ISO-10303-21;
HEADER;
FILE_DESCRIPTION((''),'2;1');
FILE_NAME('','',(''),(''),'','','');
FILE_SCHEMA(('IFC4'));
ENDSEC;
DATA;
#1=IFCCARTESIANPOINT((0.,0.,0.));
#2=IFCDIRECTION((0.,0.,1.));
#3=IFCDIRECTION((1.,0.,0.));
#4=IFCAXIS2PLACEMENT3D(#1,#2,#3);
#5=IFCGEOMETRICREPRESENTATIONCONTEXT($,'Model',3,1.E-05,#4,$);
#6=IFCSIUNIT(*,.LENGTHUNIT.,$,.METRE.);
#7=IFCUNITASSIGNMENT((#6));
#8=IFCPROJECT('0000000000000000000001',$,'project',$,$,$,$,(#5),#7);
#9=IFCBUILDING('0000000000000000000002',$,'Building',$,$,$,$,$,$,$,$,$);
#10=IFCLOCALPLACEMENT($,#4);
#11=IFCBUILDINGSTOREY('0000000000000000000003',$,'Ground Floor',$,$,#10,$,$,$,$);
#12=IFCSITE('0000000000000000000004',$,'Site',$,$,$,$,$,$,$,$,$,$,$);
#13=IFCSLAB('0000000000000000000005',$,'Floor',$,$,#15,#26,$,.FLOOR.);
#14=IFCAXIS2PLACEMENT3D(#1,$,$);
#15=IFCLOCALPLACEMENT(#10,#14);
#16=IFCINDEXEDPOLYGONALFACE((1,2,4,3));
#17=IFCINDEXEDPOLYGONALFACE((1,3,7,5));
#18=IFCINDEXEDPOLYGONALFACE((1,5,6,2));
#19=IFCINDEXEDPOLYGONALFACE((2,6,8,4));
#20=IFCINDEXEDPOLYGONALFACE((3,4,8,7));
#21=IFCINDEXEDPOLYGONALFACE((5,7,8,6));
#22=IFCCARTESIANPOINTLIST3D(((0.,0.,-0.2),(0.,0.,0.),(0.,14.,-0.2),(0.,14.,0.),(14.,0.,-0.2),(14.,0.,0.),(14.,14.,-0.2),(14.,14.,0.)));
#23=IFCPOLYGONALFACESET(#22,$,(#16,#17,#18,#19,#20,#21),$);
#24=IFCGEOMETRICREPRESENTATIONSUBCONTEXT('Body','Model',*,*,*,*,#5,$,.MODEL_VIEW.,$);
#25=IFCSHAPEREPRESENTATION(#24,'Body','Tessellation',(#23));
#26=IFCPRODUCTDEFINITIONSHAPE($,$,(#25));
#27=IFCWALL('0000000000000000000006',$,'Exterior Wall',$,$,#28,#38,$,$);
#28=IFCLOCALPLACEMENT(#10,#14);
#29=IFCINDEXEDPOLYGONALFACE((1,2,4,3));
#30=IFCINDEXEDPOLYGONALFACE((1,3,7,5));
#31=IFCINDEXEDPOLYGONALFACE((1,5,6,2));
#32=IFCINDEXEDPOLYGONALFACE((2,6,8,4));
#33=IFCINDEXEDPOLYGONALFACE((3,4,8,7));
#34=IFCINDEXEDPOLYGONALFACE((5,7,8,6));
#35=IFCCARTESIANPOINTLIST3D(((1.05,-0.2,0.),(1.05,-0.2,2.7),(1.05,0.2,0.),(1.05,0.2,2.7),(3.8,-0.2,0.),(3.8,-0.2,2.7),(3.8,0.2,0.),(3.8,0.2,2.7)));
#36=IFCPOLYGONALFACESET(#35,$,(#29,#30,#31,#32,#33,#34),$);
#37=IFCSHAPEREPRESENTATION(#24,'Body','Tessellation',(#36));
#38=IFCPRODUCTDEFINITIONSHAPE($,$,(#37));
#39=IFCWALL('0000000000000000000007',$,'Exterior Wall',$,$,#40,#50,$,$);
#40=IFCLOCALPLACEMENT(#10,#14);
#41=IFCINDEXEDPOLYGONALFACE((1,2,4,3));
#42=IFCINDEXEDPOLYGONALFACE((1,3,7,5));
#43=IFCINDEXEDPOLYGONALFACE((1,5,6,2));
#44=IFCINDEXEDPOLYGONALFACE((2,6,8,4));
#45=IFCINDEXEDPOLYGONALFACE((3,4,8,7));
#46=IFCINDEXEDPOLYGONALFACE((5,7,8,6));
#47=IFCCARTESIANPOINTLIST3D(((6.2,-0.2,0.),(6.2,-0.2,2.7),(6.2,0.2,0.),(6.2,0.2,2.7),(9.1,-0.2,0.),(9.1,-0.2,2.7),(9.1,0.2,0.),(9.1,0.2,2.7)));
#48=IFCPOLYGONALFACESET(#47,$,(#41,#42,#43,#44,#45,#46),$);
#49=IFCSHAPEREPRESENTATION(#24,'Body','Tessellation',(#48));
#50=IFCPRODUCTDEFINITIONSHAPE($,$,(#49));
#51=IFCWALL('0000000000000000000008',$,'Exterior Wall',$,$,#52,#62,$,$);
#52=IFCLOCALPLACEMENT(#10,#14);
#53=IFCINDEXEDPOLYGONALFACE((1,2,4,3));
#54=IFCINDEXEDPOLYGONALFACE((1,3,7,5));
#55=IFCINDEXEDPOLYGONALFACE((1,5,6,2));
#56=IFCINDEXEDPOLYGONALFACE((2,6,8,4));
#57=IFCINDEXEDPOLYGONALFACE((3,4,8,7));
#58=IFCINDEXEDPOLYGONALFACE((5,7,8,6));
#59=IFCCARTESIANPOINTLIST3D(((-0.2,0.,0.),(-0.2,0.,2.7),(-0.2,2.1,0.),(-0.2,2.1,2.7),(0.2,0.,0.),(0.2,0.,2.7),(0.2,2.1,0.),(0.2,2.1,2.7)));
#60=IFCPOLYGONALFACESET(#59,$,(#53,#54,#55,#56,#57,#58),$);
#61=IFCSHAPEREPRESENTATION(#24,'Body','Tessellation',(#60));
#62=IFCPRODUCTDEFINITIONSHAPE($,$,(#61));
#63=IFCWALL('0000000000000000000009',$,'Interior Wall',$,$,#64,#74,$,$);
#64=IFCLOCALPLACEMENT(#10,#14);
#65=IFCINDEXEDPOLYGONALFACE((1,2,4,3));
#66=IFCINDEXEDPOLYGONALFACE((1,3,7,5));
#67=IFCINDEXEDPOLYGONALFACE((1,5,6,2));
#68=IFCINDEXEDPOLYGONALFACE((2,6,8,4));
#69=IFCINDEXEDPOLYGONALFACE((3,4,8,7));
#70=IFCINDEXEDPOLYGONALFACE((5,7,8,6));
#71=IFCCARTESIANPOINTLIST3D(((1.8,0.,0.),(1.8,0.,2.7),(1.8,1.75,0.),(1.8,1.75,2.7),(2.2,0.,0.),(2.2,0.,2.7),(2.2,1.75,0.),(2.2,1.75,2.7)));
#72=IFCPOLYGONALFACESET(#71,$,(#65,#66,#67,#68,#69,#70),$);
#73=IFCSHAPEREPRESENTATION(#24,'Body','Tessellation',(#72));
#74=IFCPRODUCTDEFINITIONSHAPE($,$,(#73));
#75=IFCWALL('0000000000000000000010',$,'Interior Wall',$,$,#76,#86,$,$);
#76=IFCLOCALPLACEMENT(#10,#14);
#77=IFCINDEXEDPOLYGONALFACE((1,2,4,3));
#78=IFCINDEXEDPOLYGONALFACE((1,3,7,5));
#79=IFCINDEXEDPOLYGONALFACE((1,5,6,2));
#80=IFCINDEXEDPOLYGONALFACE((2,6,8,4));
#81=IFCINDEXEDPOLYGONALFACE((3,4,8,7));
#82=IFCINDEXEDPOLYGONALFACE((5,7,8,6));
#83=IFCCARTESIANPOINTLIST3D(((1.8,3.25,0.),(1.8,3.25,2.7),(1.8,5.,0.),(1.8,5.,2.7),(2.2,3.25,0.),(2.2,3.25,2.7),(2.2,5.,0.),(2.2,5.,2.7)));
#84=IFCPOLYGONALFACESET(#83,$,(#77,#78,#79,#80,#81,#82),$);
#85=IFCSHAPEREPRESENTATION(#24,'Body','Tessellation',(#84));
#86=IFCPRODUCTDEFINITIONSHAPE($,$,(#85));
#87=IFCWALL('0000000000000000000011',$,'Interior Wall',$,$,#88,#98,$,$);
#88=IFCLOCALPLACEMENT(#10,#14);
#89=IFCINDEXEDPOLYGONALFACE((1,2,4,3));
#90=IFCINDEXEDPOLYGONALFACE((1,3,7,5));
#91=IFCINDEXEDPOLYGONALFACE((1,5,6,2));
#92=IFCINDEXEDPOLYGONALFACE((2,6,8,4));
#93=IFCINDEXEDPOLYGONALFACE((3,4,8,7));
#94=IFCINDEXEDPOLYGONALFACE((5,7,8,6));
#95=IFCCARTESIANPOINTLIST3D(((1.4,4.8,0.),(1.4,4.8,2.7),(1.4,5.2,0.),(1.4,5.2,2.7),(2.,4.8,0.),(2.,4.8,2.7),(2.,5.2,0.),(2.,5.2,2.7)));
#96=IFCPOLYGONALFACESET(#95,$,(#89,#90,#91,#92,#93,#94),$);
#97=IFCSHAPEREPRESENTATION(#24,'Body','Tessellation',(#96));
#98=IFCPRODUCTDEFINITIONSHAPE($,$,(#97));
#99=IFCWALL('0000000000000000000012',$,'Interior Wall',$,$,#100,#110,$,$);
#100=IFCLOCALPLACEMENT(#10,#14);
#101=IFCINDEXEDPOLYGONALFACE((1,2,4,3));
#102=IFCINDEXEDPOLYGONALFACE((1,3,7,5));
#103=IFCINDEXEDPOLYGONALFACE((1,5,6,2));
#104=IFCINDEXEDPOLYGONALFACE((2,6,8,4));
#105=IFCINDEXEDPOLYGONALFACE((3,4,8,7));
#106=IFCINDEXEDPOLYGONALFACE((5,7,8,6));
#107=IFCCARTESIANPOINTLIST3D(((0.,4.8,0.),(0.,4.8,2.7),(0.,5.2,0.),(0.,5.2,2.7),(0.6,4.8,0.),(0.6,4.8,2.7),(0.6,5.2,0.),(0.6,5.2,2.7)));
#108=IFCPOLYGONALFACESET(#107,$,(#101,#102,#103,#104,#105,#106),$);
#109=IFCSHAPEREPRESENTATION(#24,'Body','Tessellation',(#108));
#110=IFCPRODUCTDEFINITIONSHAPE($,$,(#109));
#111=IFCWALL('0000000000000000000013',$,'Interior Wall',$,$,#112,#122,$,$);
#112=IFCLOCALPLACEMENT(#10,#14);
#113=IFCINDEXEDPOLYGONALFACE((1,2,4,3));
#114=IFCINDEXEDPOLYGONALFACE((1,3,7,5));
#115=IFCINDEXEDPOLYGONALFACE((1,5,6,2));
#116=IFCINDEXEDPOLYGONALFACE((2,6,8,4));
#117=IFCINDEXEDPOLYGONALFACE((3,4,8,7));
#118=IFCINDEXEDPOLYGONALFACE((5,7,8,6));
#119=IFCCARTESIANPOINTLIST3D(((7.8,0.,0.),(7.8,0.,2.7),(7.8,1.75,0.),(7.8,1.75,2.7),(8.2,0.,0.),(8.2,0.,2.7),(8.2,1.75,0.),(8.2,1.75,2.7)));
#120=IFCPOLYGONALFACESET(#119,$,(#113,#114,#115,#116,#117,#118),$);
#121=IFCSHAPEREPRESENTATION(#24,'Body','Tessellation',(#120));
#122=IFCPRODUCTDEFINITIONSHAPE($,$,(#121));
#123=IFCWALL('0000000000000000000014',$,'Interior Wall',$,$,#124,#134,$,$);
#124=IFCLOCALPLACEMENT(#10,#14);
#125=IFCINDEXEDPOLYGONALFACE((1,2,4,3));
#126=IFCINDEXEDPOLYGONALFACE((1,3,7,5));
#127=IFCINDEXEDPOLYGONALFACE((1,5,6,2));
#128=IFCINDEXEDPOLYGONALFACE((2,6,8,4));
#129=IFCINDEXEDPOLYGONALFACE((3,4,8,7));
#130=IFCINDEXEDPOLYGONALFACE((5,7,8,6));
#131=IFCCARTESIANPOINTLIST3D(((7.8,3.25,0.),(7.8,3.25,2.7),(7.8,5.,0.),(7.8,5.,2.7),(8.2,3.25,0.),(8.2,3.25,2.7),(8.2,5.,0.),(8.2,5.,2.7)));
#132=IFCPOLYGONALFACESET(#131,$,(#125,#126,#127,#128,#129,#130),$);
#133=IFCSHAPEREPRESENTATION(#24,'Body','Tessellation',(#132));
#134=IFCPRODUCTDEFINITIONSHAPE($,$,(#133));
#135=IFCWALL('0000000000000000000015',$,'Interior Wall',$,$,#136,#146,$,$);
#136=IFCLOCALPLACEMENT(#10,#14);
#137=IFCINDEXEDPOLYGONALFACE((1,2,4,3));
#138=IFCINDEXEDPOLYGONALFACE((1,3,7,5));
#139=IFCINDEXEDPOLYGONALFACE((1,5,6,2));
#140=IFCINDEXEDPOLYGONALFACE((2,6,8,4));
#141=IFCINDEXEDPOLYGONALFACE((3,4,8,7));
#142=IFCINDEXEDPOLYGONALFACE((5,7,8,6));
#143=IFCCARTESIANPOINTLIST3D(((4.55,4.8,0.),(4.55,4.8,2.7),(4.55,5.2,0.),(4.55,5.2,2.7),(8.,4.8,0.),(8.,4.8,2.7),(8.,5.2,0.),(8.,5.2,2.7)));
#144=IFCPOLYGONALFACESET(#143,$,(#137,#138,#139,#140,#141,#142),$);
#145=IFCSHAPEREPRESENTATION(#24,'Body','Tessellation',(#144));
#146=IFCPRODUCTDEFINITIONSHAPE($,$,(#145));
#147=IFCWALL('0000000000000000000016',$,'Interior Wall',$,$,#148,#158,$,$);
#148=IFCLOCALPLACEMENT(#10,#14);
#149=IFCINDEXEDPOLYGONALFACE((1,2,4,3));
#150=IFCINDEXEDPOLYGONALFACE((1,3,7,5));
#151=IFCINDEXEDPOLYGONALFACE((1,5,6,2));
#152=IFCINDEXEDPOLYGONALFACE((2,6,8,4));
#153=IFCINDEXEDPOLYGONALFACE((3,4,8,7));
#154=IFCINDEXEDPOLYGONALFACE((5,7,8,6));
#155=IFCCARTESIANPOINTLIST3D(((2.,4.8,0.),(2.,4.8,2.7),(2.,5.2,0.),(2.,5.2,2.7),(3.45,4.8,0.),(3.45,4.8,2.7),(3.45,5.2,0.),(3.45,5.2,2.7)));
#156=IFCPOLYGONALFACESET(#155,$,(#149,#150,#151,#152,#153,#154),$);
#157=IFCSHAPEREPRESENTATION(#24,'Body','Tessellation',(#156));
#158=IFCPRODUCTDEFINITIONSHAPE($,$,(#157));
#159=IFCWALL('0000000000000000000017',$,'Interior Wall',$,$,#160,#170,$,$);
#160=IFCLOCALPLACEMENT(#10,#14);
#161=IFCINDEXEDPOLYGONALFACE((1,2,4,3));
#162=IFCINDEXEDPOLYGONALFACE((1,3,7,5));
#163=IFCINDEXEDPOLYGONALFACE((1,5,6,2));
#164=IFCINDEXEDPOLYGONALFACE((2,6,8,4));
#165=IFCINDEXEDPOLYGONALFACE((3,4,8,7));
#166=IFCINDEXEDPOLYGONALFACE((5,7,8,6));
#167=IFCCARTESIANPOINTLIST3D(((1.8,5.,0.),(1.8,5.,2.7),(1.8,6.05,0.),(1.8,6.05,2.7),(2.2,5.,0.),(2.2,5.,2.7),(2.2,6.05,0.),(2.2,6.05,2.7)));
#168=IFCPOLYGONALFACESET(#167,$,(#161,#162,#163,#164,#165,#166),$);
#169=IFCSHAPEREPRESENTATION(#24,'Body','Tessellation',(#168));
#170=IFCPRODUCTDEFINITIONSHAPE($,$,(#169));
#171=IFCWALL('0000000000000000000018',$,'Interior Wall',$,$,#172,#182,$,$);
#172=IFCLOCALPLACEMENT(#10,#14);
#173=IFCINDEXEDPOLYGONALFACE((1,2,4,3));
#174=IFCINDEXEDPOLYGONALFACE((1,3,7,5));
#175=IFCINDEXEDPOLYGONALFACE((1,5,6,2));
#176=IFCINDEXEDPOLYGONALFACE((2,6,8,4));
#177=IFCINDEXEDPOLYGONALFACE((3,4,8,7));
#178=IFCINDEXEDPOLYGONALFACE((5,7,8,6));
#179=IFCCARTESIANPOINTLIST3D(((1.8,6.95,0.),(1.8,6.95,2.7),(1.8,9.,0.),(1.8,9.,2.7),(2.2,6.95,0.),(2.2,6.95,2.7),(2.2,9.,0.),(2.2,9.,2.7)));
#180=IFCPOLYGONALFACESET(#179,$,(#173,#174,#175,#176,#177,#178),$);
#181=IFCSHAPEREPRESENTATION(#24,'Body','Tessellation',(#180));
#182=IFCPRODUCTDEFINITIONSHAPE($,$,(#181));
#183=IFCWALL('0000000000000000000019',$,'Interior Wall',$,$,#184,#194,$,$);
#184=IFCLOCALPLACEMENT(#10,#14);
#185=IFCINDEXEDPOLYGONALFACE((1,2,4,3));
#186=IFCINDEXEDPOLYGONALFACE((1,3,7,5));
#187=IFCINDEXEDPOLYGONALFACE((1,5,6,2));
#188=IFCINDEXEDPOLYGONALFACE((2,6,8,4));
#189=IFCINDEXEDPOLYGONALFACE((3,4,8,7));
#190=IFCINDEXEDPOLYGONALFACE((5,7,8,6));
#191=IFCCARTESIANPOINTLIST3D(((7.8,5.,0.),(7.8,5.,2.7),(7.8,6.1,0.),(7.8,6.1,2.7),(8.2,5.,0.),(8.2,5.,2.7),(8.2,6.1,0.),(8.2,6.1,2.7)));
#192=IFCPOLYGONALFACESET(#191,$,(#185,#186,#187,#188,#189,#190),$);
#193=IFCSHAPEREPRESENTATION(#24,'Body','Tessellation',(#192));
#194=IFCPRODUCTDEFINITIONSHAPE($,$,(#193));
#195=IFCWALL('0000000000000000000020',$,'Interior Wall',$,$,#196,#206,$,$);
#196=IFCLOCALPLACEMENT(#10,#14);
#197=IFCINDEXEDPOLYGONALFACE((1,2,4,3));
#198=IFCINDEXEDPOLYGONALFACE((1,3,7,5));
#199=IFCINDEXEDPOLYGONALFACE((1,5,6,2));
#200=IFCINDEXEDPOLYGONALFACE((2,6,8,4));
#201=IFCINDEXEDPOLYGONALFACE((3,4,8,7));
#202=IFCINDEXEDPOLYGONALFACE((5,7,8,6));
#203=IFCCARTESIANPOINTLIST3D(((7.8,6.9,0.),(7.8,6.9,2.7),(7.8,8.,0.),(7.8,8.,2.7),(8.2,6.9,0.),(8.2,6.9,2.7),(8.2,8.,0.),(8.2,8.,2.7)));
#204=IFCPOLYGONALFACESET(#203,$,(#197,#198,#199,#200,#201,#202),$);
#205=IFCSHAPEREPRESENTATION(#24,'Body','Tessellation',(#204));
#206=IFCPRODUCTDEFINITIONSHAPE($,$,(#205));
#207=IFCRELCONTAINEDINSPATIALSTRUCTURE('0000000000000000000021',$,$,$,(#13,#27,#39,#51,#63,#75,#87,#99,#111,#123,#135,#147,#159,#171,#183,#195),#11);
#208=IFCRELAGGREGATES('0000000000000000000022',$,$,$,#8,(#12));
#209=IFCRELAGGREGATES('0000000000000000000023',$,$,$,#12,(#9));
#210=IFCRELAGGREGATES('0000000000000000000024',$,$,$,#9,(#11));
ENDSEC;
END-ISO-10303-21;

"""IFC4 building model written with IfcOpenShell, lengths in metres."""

from ifc_helpers import new_model, si_unit, frame, origin_with_axes, place, context, subcontext, project, spatial, indexed_curve, outline, extrude, element, save


model = new_model("IFC4")

# Units and contexts
model_context = context("Model", 3, precision=1e-05, world=origin_with_axes())
body_context = subcontext(model_context, "Body", "Model", "MODEL_VIEW")
ifc_project = project(units=[si_unit("LENGTHUNIT", "METRE")], contexts=[model_context])

# Site, building, storey
site = spatial("IfcSite", under=ifc_project, Name="Site")
building = spatial("IfcBuilding", under=site, Name="Building")
storey_placement = place(None, origin_with_axes())
storey = spatial("IfcBuildingStorey", under=building, at=storey_placement, Name="Ground Floor")

# Slab
slab_placement = place(storey_placement, frame((0.0, 0.0, -0.2), z_axis=(0.0, 0.0, 1.0), x_axis=(1.0, 0.0, 0.0)))
element("IfcSlab", 1, at=slab_placement, inside=storey, Name="Floor", PredefinedType="FLOOR", context=body_context, shape_type="SweptSolid", body=[
    extrude(outline(indexed_curve([(0.0, 0.0), (14.0, 0.0), (14.0, 14.0), (0.0, 14.0)])), None, (0.0, 0.0, 1.0), 0.2),
])

# Walls
wall_1_placement = place(storey_placement, frame((1.05, 0.0, 0.0), z_axis=(0.0, 0.0, 1.0), x_axis=(1.0, 0.0, 0.0)))
element("IfcWall", 2, at=wall_1_placement, inside=storey, Name="Exterior Wall", context=body_context, shape_type="SweptSolid", body=[
    extrude(outline(indexed_curve([(0.0, 0.0), (0.0, 0.4), (2.75, 0.4), (2.75, 0.0), (0.0, 0.0)], self_intersect=False)), frame((0.0, -0.2, 0.0), z_axis=(0.0, 0.0, 1.0), x_axis=(1.0, 0.0, 0.0)), (0.0, 0.0, 1.0), 2.7),
])
wall_2_placement = place(storey_placement, frame((6.2, 0.0, 0.0), z_axis=(0.0, 0.0, 1.0), x_axis=(1.0, 0.0, 0.0)))
element("IfcWall", 3, at=wall_2_placement, inside=storey, Name="Exterior Wall", context=body_context, shape_type="SweptSolid", body=[
    extrude(outline(indexed_curve([(0.0, 0.0), (0.0, 0.4), (2.9, 0.4), (2.9, 0.0), (0.0, 0.0)], self_intersect=False)), frame((0.0, -0.2, 0.0), z_axis=(0.0, 0.0, 1.0), x_axis=(1.0, 0.0, 0.0)), (0.0, 0.0, 1.0), 2.7),
])
wall_3_placement = place(storey_placement, frame((0.0, 2.1, 0.0), z_axis=(0.0, 0.0, 1.0), x_axis=(0.0, -1.0, 0.0)))
element("IfcWall", 4, at=wall_3_placement, inside=storey, Name="Exterior Wall", context=body_context, shape_type="SweptSolid", body=[
    extrude(outline(indexed_curve([(0.0, 0.0), (0.0, 0.4), (2.1, 0.4), (2.1, 0.0), (0.0, 0.0)], self_intersect=False)), frame((0.0, -0.2, 0.0), z_axis=(0.0, 0.0, 1.0), x_axis=(1.0, 0.0, 0.0)), (0.0, 0.0, 1.0), 2.7),
])
for number, where, z_axis, x_axis, name in (
    (5, (2.0, 0.0, 0.0), (0.0, 0.0, 1.0), (0.0, 1.0, 0.0), "Interior Wall"),
    (6, (2.0, 3.25, 0.0), (0.0, 0.0, 1.0), (0.0, 1.0, 0.0), "Interior Wall"),
):
    element("IfcWall", number, at=place(storey_placement, frame(where, z_axis=z_axis, x_axis=x_axis)), inside=storey, Name=name, context=body_context, shape_type="SweptSolid", body=[
        extrude(outline(indexed_curve([(0.0, 0.0), (0.0, 0.4), (1.75, 0.4), (1.75, 0.0), (0.0, 0.0)], self_intersect=False)), frame((0.0, -0.2, 0.0), z_axis=(0.0, 0.0, 1.0), x_axis=(1.0, 0.0, 0.0)), (0.0, 0.0, 1.0), 2.7),
    ])
for number, where, z_axis, x_axis, name in (
    (7, (2.0, 5.0, 0.0), (0.0, 0.0, 1.0), (-1.0, 0.0, 0.0), "Interior Wall"),
    (8, (0.6, 5.0, 0.0), (0.0, 0.0, 1.0), (-1.0, 0.0, 0.0), "Interior Wall"),
):
    element("IfcWall", number, at=place(storey_placement, frame(where, z_axis=z_axis, x_axis=x_axis)), inside=storey, Name=name, context=body_context, shape_type="SweptSolid", body=[
        extrude(outline(indexed_curve([(0.0, 0.0), (0.0, 0.4), (0.6, 0.4), (0.6, 0.0), (0.0, 0.0)], self_intersect=False)), frame((0.0, -0.2, 0.0), z_axis=(0.0, 0.0, 1.0), x_axis=(1.0, 0.0, 0.0)), (0.0, 0.0, 1.0), 2.7),
    ])
for number, where, z_axis, x_axis, name in (
    (9, (8.0, 0.0, 0.0), (0.0, 0.0, 1.0), (0.0, 1.0, 0.0), "Interior Wall"),
    (10, (8.0, 3.25, 0.0), (0.0, 0.0, 1.0), (0.0, 1.0, 0.0), "Interior Wall"),
):
    element("IfcWall", number, at=place(storey_placement, frame(where, z_axis=z_axis, x_axis=x_axis)), inside=storey, Name=name, context=body_context, shape_type="SweptSolid", body=[
        extrude(outline(indexed_curve([(0.0, 0.0), (0.0, 0.4), (1.75, 0.4), (1.75, 0.0), (0.0, 0.0)], self_intersect=False)), frame((0.0, -0.2, 0.0), z_axis=(0.0, 0.0, 1.0), x_axis=(1.0, 0.0, 0.0)), (0.0, 0.0, 1.0), 2.7),
    ])
wall_4_placement = place(storey_placement, frame((8.0, 5.0, 0.0), z_axis=(0.0, 0.0, 1.0), x_axis=(-1.0, 0.0, 0.0)))
element("IfcWall", 11, at=wall_4_placement, inside=storey, Name="Interior Wall", context=body_context, shape_type="SweptSolid", body=[
    extrude(outline(indexed_curve([(0.0, 0.0), (0.0, 0.4), (3.45, 0.4), (3.45, 0.0), (0.0, 0.0)], self_intersect=False)), frame((0.0, -0.2, 0.0), z_axis=(0.0, 0.0, 1.0), x_axis=(1.0, 0.0, 0.0)), (0.0, 0.0, 1.0), 2.7),
])
wall_5_placement = place(storey_placement, frame((3.45, 5.0, 0.0), z_axis=(0.0, 0.0, 1.0), x_axis=(-1.0, 0.0, 0.0)))
element("IfcWall", 12, at=wall_5_placement, inside=storey, Name="Interior Wall", context=body_context, shape_type="SweptSolid", body=[
    extrude(outline(indexed_curve([(0.0, 0.0), (0.0, 0.4), (1.45, 0.4), (1.45, 0.0), (0.0, 0.0)], self_intersect=False)), frame((0.0, -0.2, 0.0), z_axis=(0.0, 0.0, 1.0), x_axis=(1.0, 0.0, 0.0)), (0.0, 0.0, 1.0), 2.7),
])
wall_6_placement = place(storey_placement, frame((2.0, 5.0, 0.0), z_axis=(0.0, 0.0, 1.0), x_axis=(0.0, 1.0, 0.0)))
element("IfcWall", 13, at=wall_6_placement, inside=storey, Name="Interior Wall", context=body_context, shape_type="SweptSolid", body=[
    extrude(outline(indexed_curve([(0.0, 0.0), (0.0, 0.4), (1.05, 0.4), (1.05, 0.0), (0.0, 0.0)], self_intersect=False)), frame((0.0, -0.2, 0.0), z_axis=(0.0, 0.0, 1.0), x_axis=(1.0, 0.0, 0.0)), (0.0, 0.0, 1.0), 2.7),
])
wall_7_placement = place(storey_placement, frame((2.0, 6.95, 0.0), z_axis=(0.0, 0.0, 1.0), x_axis=(0.0, 1.0, 0.0)))
element("IfcWall", 14, at=wall_7_placement, inside=storey, Name="Interior Wall", context=body_context, shape_type="SweptSolid", body=[
    extrude(outline(indexed_curve([(0.0, 0.0), (0.0, 0.4), (2.05, 0.4), (2.05, 0.0), (0.0, 0.0)], self_intersect=False)), frame((0.0, -0.2, 0.0), z_axis=(0.0, 0.0, 1.0), x_axis=(1.0, 0.0, 0.0)), (0.0, 0.0, 1.0), 2.7),
])
for number, where, z_axis, x_axis, name in (
    (15, (8.0, 5.0, 0.0), (0.0, 0.0, 1.0), (0.0, 1.0, 0.0), "Interior Wall"),
    (16, (8.0, 6.9, 0.0), (0.0, 0.0, 1.0), (0.0, 1.0, 0.0), "Interior Wall"),
):
    element("IfcWall", number, at=place(storey_placement, frame(where, z_axis=z_axis, x_axis=x_axis)), inside=storey, Name=name, context=body_context, shape_type="SweptSolid", body=[
        extrude(outline(indexed_curve([(0.0, 0.0), (0.0, 0.4), (1.1, 0.4), (1.1, 0.0), (0.0, 0.0)], self_intersect=False)), frame((0.0, -0.2, 0.0), z_axis=(0.0, 0.0, 1.0), x_axis=(1.0, 0.0, 0.0)), (0.0, 0.0, 1.0), 2.7),
    ])

save(model, "model.ifc")
